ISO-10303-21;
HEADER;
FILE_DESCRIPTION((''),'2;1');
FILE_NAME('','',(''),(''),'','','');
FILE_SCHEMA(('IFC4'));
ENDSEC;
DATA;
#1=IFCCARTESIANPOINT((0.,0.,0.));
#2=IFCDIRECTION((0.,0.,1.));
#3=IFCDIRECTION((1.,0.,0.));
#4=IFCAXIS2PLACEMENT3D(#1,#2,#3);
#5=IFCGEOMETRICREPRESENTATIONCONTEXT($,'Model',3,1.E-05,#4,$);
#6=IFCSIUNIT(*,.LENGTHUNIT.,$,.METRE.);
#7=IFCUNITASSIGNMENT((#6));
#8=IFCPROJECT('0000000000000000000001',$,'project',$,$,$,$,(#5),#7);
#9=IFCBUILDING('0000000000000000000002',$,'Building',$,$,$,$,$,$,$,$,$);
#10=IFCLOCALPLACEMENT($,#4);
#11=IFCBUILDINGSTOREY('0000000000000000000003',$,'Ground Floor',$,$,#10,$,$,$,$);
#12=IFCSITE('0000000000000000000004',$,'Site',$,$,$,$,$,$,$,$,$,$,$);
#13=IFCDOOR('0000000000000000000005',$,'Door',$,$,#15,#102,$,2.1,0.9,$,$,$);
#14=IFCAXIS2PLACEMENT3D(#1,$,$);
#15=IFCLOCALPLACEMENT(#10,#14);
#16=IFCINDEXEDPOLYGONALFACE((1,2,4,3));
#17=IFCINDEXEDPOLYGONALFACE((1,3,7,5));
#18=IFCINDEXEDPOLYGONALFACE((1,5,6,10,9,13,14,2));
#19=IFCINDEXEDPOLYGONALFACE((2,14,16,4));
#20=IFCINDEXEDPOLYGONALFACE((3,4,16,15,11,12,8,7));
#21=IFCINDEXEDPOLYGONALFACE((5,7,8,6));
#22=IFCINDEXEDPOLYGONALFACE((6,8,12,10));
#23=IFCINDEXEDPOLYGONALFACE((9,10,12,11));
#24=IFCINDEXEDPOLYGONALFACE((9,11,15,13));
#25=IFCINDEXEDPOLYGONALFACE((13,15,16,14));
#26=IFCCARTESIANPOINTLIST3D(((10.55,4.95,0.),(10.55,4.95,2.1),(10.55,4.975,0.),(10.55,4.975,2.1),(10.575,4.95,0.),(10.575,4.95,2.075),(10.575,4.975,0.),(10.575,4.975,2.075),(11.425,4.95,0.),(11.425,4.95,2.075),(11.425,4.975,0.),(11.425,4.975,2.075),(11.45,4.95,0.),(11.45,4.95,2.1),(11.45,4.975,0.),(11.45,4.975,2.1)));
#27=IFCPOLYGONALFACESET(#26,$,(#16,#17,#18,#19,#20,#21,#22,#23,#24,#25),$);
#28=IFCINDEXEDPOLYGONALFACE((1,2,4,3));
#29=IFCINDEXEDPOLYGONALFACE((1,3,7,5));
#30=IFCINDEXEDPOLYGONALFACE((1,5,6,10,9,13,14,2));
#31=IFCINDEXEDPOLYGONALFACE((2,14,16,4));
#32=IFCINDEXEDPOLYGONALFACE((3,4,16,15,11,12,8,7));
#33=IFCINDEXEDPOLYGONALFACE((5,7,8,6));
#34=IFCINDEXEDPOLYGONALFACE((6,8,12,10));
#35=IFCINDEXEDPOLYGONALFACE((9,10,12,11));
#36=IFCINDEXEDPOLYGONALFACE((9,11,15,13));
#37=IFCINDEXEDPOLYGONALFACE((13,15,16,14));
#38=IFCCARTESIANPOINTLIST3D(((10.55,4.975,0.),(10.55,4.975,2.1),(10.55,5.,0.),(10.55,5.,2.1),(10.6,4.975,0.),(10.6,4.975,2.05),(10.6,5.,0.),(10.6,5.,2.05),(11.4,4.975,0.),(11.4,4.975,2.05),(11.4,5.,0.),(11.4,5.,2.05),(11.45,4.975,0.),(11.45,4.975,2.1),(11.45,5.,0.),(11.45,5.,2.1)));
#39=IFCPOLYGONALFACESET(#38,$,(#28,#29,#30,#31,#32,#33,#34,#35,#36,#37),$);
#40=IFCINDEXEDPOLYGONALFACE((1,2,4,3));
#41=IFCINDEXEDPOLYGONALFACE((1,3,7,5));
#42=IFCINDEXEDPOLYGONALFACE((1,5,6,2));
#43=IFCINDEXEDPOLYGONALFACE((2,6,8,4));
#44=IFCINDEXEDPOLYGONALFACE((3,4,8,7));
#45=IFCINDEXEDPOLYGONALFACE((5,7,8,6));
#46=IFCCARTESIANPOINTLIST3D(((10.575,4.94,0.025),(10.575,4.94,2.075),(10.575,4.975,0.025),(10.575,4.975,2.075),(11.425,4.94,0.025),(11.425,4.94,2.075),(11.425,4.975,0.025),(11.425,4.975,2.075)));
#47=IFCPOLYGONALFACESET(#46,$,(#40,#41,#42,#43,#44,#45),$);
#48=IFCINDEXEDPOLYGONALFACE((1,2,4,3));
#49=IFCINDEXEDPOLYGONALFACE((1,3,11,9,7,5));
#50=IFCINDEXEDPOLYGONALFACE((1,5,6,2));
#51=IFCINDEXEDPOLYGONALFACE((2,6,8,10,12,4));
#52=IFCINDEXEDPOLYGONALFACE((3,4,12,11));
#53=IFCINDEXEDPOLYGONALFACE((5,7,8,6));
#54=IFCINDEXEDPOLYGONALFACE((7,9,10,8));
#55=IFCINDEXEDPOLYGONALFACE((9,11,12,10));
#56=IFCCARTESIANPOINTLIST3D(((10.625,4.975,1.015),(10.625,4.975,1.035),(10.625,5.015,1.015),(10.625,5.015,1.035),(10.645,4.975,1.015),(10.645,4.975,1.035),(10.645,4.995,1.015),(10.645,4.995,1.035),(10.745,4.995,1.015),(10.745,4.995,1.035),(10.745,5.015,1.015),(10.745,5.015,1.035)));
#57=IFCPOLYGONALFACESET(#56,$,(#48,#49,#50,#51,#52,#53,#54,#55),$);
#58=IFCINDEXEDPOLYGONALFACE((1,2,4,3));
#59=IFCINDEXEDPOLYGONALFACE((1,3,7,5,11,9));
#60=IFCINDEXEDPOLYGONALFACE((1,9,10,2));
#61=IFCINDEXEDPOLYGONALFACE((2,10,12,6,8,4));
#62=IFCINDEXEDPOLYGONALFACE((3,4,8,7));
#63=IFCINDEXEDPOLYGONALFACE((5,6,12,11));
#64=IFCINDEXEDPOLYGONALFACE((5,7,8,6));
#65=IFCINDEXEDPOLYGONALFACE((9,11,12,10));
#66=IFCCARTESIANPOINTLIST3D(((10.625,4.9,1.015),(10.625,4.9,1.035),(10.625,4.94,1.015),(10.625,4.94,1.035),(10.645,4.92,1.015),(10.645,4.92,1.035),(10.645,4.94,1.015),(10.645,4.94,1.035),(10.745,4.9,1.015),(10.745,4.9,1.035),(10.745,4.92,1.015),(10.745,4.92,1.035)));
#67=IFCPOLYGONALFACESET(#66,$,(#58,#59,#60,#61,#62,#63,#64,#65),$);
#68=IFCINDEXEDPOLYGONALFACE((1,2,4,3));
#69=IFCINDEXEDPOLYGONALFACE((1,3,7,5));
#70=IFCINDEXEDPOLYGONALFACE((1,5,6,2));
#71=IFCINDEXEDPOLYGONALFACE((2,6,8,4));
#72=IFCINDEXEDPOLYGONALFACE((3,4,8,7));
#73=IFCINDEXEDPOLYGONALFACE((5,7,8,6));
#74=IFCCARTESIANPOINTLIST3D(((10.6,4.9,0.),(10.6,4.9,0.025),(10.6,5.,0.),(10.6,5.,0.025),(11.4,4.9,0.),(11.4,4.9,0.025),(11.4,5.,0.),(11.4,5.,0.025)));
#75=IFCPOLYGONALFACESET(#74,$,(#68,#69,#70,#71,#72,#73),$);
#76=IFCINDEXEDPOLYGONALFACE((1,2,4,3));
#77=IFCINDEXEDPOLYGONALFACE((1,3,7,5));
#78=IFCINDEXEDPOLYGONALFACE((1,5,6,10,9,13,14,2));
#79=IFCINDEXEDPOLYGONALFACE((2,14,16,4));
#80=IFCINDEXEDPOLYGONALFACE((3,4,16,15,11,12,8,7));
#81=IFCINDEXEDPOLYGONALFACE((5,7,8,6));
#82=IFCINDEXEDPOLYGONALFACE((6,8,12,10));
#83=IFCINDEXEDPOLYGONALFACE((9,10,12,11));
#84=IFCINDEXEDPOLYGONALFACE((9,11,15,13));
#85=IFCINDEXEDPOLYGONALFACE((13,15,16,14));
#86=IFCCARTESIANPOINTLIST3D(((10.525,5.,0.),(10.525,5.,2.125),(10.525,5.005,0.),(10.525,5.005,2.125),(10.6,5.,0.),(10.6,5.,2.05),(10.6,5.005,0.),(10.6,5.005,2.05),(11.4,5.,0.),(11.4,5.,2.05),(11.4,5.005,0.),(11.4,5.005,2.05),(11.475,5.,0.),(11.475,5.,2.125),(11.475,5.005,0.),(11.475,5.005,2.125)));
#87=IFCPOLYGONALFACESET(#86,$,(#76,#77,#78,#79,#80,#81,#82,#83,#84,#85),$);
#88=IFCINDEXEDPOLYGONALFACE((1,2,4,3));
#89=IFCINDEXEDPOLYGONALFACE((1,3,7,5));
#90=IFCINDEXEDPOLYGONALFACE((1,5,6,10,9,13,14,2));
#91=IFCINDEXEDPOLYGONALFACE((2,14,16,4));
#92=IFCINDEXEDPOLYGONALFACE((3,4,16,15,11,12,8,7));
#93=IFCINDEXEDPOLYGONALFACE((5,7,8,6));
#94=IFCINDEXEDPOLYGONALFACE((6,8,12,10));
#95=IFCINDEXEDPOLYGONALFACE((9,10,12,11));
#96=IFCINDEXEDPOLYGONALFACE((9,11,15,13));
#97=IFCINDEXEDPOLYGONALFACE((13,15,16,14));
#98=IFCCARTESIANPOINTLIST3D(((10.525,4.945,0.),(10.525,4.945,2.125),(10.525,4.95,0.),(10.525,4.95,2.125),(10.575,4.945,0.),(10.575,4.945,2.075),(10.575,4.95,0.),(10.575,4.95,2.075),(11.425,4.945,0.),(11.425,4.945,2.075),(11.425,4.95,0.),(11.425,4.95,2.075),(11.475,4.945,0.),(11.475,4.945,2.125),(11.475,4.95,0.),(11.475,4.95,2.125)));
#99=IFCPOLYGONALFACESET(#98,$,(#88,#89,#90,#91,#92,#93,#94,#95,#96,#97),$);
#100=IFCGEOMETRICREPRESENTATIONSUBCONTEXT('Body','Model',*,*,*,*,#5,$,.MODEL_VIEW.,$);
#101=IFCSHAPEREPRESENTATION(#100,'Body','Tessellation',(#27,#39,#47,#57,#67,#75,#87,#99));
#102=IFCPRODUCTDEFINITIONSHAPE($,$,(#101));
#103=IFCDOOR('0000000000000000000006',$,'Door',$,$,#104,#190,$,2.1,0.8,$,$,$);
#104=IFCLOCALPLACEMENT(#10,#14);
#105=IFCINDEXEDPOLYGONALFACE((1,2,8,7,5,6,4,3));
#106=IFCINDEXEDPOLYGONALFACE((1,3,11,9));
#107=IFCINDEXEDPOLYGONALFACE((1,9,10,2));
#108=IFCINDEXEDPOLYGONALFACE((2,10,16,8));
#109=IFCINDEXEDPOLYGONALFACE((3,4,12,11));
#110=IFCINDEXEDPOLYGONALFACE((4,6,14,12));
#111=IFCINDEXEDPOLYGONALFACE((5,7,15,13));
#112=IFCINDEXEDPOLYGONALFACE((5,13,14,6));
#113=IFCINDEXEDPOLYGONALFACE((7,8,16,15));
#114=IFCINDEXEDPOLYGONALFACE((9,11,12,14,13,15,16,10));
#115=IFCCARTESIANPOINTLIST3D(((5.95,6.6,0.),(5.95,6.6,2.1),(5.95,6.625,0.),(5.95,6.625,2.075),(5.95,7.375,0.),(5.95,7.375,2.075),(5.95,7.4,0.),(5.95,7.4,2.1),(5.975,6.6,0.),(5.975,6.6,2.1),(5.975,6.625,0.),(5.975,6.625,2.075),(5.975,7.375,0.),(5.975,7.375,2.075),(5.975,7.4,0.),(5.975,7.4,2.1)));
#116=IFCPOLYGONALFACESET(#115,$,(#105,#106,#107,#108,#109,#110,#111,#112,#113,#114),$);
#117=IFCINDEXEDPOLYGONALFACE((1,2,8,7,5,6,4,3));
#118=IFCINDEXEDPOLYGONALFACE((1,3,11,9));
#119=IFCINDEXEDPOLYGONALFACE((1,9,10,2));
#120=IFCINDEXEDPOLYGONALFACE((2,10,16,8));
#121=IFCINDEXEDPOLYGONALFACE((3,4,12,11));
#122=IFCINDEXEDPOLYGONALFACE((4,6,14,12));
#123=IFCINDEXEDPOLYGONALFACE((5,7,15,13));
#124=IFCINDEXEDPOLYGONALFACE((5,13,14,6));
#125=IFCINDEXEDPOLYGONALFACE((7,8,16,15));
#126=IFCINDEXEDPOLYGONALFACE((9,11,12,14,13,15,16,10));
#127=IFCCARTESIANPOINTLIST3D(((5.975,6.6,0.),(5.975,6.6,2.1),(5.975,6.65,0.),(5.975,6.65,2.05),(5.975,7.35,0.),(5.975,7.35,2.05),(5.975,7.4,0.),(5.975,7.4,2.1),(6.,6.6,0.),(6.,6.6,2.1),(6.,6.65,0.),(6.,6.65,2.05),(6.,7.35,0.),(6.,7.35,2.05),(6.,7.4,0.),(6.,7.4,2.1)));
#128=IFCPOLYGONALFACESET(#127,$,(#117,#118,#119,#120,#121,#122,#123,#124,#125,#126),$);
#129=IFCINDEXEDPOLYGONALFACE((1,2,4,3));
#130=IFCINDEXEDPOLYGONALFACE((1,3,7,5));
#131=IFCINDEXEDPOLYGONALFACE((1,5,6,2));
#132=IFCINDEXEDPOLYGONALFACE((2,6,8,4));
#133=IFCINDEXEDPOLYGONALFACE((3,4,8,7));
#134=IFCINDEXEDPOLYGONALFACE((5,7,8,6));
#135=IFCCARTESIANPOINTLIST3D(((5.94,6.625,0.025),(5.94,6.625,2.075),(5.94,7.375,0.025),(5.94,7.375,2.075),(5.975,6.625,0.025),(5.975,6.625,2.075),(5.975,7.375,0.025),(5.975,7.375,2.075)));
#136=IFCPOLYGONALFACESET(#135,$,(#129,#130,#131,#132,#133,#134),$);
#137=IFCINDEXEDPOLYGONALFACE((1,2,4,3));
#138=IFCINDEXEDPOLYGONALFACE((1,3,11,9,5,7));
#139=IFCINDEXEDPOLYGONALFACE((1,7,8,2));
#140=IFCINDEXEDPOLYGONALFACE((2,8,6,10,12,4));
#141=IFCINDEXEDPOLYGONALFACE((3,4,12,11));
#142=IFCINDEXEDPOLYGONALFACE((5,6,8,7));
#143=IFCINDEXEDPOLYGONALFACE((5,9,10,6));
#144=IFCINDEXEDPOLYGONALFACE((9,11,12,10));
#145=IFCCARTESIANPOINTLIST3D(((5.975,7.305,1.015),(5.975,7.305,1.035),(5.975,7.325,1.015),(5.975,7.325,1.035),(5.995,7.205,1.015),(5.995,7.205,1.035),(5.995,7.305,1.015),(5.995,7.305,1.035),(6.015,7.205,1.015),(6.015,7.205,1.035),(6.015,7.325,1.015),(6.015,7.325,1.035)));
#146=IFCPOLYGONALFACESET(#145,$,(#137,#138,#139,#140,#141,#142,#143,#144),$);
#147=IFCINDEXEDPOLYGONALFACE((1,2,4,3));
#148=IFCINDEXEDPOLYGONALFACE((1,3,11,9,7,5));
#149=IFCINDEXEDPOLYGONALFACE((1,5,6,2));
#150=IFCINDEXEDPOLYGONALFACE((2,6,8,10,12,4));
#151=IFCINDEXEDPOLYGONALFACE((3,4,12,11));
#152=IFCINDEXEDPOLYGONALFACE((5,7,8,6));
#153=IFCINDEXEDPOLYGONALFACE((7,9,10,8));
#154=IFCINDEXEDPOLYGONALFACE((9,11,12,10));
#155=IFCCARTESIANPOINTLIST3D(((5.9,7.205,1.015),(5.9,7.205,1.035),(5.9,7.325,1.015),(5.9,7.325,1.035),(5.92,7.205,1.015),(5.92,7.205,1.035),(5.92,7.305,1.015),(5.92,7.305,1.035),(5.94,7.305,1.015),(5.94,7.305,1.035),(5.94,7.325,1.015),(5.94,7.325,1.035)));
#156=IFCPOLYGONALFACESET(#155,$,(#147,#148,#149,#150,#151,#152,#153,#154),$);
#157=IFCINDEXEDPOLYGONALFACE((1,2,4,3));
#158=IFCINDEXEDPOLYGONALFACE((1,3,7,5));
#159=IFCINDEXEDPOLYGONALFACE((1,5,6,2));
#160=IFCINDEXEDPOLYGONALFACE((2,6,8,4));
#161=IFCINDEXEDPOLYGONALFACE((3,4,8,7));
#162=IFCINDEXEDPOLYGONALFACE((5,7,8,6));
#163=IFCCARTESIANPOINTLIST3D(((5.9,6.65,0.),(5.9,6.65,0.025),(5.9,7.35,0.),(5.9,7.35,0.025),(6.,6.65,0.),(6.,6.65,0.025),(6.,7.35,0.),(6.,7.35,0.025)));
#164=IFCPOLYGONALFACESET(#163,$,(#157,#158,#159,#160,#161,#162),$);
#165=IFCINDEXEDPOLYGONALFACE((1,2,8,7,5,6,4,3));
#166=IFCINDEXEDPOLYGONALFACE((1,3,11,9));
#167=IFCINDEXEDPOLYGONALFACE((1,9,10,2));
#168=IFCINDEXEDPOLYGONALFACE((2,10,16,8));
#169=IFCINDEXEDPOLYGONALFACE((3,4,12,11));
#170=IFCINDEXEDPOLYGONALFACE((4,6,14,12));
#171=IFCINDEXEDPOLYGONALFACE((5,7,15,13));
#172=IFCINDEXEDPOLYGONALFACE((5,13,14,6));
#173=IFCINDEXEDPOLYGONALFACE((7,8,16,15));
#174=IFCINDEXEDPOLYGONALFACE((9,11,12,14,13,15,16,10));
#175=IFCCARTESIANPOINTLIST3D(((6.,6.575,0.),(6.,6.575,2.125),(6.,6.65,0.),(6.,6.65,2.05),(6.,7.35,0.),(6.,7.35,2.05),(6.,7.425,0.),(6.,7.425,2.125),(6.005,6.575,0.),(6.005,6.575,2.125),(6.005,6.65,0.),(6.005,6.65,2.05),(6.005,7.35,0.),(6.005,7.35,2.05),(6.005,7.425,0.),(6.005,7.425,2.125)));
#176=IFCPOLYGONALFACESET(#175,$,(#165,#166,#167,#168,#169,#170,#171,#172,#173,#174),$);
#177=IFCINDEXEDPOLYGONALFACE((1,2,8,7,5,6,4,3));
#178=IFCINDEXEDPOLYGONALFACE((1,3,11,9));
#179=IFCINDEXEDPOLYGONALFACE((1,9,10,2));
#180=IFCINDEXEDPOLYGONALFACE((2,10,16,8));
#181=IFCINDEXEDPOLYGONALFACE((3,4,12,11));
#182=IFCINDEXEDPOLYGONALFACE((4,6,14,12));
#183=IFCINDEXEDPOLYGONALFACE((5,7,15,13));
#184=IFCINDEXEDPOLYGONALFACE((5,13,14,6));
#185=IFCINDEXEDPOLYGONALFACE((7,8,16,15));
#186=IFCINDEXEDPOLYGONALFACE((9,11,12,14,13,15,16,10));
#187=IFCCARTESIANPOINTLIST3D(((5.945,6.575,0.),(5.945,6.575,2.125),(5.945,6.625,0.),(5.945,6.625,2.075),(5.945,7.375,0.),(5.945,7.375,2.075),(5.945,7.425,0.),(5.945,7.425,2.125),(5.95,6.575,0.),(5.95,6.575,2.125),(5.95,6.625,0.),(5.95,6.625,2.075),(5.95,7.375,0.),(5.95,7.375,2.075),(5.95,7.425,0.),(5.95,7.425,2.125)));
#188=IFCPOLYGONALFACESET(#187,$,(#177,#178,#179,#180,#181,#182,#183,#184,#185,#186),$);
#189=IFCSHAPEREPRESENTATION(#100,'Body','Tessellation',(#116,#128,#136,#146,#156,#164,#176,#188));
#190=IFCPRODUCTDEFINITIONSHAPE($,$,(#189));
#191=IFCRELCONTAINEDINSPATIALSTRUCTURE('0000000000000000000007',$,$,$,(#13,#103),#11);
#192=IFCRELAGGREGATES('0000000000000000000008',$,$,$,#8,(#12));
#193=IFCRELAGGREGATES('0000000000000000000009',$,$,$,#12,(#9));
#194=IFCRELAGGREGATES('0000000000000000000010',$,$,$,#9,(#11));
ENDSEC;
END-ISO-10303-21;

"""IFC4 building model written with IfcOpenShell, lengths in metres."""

from ifc_helpers import new_model, si_unit, frame, origin_with_axes, place, context, subcontext, project, spatial, line, indexed_curve, outline, extrude, element, save


model = new_model("IFC4")

# Units and contexts
model_context = context("Model", 3, precision=1e-05, world=origin_with_axes())
body_context = subcontext(model_context, "Body", "Model", "MODEL_VIEW")
ifc_project = project(units=[si_unit("LENGTHUNIT", "METRE")], contexts=[model_context])

# Site, building, storey
site = spatial("IfcSite", under=ifc_project, Name="Site")
building = spatial("IfcBuilding", under=site, Name="Building")
storey_placement = place(None, origin_with_axes())
storey = spatial("IfcBuildingStorey", under=building, at=storey_placement, Name="Ground Floor")

# Doors
door_1_placement = place(storey_placement, frame((11.45, 5.0, 0.0), z_axis=(0.0, 0.0, 1.0), x_axis=(-1.0, 0.0, 0.0)))
element("IfcDoor", 1, at=door_1_placement, inside=storey, Name="Door", OverallHeight=2.1, OverallWidth=0.9, context=body_context, shape_type="SweptSolid", body=[
    extrude(outline(indexed_curve([(0.0, 0.0), (0.0, 2.1), (0.9, 2.1), (0.9, 0.0), (0.875, 0.0), (0.875, 2.075), (0.025, 2.075), (0.025, 0.0)], segments=[line(1, 2, 3, 4, 5, 6, 7, 8, 1)])), frame((0.0, 0.025, 0.0), z_axis=(0.0, -1.0, 0.0), x_axis=(1.0, 0.0, 0.0)), (0.0, 0.0, -1.0), 0.025),
    extrude(outline(indexed_curve([(0.0, 0.0), (0.0, 2.1), (0.9, 2.1), (0.9, 0.0), (0.85, 0.0), (0.85, 2.05), (0.05, 2.05), (0.05, 0.0)], segments=[line(1, 2, 3, 4, 5, 6, 7, 8, 1)])), frame((0.0, 0.0, 0.0), z_axis=(0.0, -1.0, 0.0), x_axis=(1.0, 0.0, 0.0)), (0.0, 0.0, -1.0), 0.025),
    extrude(outline(indexed_curve([(0.0, 0.0), (0.85, 0.0), (0.85, 0.035), (0.0, 0.035)], segments=[line(1, 2, 3, 4, 1)])), frame((0.025, 0.025, 0.025), z_axis=(0.0, 0.0, 1.0), x_axis=(1.0, 0.0, 0.0)), (0.0, 0.0, 1.0), 2.05),
    extrude(outline(indexed_curve([(0.0, 0.0), (0.0, -0.04), (-0.12, -0.04), (-0.12, -0.02), (-0.02, -0.02), (-0.02, 0.0)], segments=[line(1, 2, 3, 4, 5, 6, 1)])), frame((0.825, 0.025, 1.015), z_axis=(0.0, 0.0, 1.0), x_axis=(1.0, 0.0, 0.0)), (0.0, 0.0, 1.0), 0.02),
    extrude(outline(indexed_curve([(0.0, 0.0), (0.0, 0.04), (-0.12, 0.04), (-0.12, 0.02), (-0.02, 0.02), (-0.02, 0.0)], segments=[line(1, 2, 3, 4, 5, 6, 1)])), frame((0.825, 0.06, 1.015), z_axis=(0.0, 0.0, 1.0), x_axis=(1.0, 0.0, 0.0)), (0.0, 0.0, 1.0), 0.02),
    extrude(outline(indexed_curve([(0.0, 0.0), (0.8, 0.0), (0.8, 0.1), (0.0, 0.1)], segments=[line(1, 2, 3, 4, 1)])), frame((0.05, 0.0, 0.0), z_axis=(0.0, 0.0, 1.0), x_axis=(1.0, 0.0, 0.0)), (0.0, 0.0, 1.0), 0.025),
    extrude(outline(indexed_curve([(0.0, 0.0), (0.0, 2.125), (0.95, 2.125), (0.95, 0.0), (0.875, 0.0), (0.875, 2.05), (0.075, 2.05), (0.075, 0.0)], segments=[line(1, 2, 3, 4, 5, 6, 7, 8, 1)])), frame((-0.025, -0.005, 0.0), z_axis=(0.0, -1.0, 0.0), x_axis=(1.0, 0.0, 0.0)), (0.0, 0.0, -1.0), 0.005),
    extrude(outline(indexed_curve([(0.0, 0.0), (0.0, 2.125), (0.95, 2.125), (0.95, 0.0), (0.9, 0.0), (0.9, 2.075), (0.05, 2.075), (0.05, 0.0)], segments=[line(1, 2, 3, 4, 5, 6, 7, 8, 1)])), frame((-0.025, 0.05, 0.0), z_axis=(0.0, -1.0, 0.0), x_axis=(1.0, 0.0, 0.0)), (0.0, 0.0, -1.0), 0.005),
])
door_2_placement = place(storey_placement, frame((6.0, 6.6, 0.0), z_axis=(0.0, 0.0, 1.0), x_axis=(0.0, 1.0, 0.0)))
element("IfcDoor", 2, at=door_2_placement, inside=storey, Name="Door", OverallHeight=2.1, OverallWidth=0.8, context=body_context, shape_type="SweptSolid", body=[
    extrude(outline(indexed_curve([(0.0, 0.0), (0.0, 2.1), (0.8, 2.1), (0.8, 0.0), (0.775, 0.0), (0.775, 2.075), (0.025, 2.075), (0.025, 0.0)], segments=[line(1, 2, 3, 4, 5, 6, 7, 8, 1)])), frame((0.0, 0.025, 0.0), z_axis=(0.0, -1.0, 0.0), x_axis=(1.0, 0.0, 0.0)), (0.0, 0.0, -1.0), 0.025),
    extrude(outline(indexed_curve([(0.0, 0.0), (0.0, 2.1), (0.8, 2.1), (0.8, 0.0), (0.75, 0.0), (0.75, 2.05), (0.05, 2.05), (0.05, 0.0)], segments=[line(1, 2, 3, 4, 5, 6, 7, 8, 1)])), frame((0.0, 0.0, 0.0), z_axis=(0.0, -1.0, 0.0), x_axis=(1.0, 0.0, 0.0)), (0.0, 0.0, -1.0), 0.025),
    extrude(outline(indexed_curve([(0.0, 0.0), (0.75, 0.0), (0.75, 0.035), (0.0, 0.035)], segments=[line(1, 2, 3, 4, 1)])), frame((0.025, 0.025, 0.025), z_axis=(0.0, 0.0, 1.0), x_axis=(1.0, 0.0, 0.0)), (0.0, 0.0, 1.0), 2.05),
    extrude(outline(indexed_curve([(0.0, 0.0), (0.0, -0.04), (-0.12, -0.04), (-0.12, -0.02), (-0.02, -0.02), (-0.02, 0.0)], segments=[line(1, 2, 3, 4, 5, 6, 1)])), frame((0.725, 0.025, 1.015), z_axis=(0.0, 0.0, 1.0), x_axis=(1.0, 0.0, 0.0)), (0.0, 0.0, 1.0), 0.02),
    extrude(outline(indexed_curve([(0.0, 0.0), (0.0, 0.04), (-0.12, 0.04), (-0.12, 0.02), (-0.02, 0.02), (-0.02, 0.0)], segments=[line(1, 2, 3, 4, 5, 6, 1)])), frame((0.725, 0.06, 1.015), z_axis=(0.0, 0.0, 1.0), x_axis=(1.0, 0.0, 0.0)), (0.0, 0.0, 1.0), 0.02),
    extrude(outline(indexed_curve([(0.0, 0.0), (0.7, 0.0), (0.7, 0.1), (0.0, 0.1)], segments=[line(1, 2, 3, 4, 1)])), frame((0.05, 0.0, 0.0), z_axis=(0.0, 0.0, 1.0), x_axis=(1.0, 0.0, 0.0)), (0.0, 0.0, 1.0), 0.025),
    extrude(outline(indexed_curve([(0.0, 0.0), (0.0, 2.125), (0.85, 2.125), (0.85, 0.0), (0.775, 0.0), (0.775, 2.05), (0.075, 2.05), (0.075, 0.0)], segments=[line(1, 2, 3, 4, 5, 6, 7, 8, 1)])), frame((-0.025, -0.005, 0.0), z_axis=(0.0, -1.0, 0.0), x_axis=(1.0, 0.0, 0.0)), (0.0, 0.0, -1.0), 0.005),
    extrude(outline(indexed_curve([(0.0, 0.0), (0.0, 2.125), (0.85, 2.125), (0.85, 0.0), (0.8, 0.0), (0.8, 2.075), (0.05, 2.075), (0.05, 0.0)], segments=[line(1, 2, 3, 4, 5, 6, 7, 8, 1)])), frame((-0.025, 0.05, 0.0), z_axis=(0.0, -1.0, 0.0), x_axis=(1.0, 0.0, 0.0)), (0.0, 0.0, -1.0), 0.005),
])

save(model, "model.ifc")
